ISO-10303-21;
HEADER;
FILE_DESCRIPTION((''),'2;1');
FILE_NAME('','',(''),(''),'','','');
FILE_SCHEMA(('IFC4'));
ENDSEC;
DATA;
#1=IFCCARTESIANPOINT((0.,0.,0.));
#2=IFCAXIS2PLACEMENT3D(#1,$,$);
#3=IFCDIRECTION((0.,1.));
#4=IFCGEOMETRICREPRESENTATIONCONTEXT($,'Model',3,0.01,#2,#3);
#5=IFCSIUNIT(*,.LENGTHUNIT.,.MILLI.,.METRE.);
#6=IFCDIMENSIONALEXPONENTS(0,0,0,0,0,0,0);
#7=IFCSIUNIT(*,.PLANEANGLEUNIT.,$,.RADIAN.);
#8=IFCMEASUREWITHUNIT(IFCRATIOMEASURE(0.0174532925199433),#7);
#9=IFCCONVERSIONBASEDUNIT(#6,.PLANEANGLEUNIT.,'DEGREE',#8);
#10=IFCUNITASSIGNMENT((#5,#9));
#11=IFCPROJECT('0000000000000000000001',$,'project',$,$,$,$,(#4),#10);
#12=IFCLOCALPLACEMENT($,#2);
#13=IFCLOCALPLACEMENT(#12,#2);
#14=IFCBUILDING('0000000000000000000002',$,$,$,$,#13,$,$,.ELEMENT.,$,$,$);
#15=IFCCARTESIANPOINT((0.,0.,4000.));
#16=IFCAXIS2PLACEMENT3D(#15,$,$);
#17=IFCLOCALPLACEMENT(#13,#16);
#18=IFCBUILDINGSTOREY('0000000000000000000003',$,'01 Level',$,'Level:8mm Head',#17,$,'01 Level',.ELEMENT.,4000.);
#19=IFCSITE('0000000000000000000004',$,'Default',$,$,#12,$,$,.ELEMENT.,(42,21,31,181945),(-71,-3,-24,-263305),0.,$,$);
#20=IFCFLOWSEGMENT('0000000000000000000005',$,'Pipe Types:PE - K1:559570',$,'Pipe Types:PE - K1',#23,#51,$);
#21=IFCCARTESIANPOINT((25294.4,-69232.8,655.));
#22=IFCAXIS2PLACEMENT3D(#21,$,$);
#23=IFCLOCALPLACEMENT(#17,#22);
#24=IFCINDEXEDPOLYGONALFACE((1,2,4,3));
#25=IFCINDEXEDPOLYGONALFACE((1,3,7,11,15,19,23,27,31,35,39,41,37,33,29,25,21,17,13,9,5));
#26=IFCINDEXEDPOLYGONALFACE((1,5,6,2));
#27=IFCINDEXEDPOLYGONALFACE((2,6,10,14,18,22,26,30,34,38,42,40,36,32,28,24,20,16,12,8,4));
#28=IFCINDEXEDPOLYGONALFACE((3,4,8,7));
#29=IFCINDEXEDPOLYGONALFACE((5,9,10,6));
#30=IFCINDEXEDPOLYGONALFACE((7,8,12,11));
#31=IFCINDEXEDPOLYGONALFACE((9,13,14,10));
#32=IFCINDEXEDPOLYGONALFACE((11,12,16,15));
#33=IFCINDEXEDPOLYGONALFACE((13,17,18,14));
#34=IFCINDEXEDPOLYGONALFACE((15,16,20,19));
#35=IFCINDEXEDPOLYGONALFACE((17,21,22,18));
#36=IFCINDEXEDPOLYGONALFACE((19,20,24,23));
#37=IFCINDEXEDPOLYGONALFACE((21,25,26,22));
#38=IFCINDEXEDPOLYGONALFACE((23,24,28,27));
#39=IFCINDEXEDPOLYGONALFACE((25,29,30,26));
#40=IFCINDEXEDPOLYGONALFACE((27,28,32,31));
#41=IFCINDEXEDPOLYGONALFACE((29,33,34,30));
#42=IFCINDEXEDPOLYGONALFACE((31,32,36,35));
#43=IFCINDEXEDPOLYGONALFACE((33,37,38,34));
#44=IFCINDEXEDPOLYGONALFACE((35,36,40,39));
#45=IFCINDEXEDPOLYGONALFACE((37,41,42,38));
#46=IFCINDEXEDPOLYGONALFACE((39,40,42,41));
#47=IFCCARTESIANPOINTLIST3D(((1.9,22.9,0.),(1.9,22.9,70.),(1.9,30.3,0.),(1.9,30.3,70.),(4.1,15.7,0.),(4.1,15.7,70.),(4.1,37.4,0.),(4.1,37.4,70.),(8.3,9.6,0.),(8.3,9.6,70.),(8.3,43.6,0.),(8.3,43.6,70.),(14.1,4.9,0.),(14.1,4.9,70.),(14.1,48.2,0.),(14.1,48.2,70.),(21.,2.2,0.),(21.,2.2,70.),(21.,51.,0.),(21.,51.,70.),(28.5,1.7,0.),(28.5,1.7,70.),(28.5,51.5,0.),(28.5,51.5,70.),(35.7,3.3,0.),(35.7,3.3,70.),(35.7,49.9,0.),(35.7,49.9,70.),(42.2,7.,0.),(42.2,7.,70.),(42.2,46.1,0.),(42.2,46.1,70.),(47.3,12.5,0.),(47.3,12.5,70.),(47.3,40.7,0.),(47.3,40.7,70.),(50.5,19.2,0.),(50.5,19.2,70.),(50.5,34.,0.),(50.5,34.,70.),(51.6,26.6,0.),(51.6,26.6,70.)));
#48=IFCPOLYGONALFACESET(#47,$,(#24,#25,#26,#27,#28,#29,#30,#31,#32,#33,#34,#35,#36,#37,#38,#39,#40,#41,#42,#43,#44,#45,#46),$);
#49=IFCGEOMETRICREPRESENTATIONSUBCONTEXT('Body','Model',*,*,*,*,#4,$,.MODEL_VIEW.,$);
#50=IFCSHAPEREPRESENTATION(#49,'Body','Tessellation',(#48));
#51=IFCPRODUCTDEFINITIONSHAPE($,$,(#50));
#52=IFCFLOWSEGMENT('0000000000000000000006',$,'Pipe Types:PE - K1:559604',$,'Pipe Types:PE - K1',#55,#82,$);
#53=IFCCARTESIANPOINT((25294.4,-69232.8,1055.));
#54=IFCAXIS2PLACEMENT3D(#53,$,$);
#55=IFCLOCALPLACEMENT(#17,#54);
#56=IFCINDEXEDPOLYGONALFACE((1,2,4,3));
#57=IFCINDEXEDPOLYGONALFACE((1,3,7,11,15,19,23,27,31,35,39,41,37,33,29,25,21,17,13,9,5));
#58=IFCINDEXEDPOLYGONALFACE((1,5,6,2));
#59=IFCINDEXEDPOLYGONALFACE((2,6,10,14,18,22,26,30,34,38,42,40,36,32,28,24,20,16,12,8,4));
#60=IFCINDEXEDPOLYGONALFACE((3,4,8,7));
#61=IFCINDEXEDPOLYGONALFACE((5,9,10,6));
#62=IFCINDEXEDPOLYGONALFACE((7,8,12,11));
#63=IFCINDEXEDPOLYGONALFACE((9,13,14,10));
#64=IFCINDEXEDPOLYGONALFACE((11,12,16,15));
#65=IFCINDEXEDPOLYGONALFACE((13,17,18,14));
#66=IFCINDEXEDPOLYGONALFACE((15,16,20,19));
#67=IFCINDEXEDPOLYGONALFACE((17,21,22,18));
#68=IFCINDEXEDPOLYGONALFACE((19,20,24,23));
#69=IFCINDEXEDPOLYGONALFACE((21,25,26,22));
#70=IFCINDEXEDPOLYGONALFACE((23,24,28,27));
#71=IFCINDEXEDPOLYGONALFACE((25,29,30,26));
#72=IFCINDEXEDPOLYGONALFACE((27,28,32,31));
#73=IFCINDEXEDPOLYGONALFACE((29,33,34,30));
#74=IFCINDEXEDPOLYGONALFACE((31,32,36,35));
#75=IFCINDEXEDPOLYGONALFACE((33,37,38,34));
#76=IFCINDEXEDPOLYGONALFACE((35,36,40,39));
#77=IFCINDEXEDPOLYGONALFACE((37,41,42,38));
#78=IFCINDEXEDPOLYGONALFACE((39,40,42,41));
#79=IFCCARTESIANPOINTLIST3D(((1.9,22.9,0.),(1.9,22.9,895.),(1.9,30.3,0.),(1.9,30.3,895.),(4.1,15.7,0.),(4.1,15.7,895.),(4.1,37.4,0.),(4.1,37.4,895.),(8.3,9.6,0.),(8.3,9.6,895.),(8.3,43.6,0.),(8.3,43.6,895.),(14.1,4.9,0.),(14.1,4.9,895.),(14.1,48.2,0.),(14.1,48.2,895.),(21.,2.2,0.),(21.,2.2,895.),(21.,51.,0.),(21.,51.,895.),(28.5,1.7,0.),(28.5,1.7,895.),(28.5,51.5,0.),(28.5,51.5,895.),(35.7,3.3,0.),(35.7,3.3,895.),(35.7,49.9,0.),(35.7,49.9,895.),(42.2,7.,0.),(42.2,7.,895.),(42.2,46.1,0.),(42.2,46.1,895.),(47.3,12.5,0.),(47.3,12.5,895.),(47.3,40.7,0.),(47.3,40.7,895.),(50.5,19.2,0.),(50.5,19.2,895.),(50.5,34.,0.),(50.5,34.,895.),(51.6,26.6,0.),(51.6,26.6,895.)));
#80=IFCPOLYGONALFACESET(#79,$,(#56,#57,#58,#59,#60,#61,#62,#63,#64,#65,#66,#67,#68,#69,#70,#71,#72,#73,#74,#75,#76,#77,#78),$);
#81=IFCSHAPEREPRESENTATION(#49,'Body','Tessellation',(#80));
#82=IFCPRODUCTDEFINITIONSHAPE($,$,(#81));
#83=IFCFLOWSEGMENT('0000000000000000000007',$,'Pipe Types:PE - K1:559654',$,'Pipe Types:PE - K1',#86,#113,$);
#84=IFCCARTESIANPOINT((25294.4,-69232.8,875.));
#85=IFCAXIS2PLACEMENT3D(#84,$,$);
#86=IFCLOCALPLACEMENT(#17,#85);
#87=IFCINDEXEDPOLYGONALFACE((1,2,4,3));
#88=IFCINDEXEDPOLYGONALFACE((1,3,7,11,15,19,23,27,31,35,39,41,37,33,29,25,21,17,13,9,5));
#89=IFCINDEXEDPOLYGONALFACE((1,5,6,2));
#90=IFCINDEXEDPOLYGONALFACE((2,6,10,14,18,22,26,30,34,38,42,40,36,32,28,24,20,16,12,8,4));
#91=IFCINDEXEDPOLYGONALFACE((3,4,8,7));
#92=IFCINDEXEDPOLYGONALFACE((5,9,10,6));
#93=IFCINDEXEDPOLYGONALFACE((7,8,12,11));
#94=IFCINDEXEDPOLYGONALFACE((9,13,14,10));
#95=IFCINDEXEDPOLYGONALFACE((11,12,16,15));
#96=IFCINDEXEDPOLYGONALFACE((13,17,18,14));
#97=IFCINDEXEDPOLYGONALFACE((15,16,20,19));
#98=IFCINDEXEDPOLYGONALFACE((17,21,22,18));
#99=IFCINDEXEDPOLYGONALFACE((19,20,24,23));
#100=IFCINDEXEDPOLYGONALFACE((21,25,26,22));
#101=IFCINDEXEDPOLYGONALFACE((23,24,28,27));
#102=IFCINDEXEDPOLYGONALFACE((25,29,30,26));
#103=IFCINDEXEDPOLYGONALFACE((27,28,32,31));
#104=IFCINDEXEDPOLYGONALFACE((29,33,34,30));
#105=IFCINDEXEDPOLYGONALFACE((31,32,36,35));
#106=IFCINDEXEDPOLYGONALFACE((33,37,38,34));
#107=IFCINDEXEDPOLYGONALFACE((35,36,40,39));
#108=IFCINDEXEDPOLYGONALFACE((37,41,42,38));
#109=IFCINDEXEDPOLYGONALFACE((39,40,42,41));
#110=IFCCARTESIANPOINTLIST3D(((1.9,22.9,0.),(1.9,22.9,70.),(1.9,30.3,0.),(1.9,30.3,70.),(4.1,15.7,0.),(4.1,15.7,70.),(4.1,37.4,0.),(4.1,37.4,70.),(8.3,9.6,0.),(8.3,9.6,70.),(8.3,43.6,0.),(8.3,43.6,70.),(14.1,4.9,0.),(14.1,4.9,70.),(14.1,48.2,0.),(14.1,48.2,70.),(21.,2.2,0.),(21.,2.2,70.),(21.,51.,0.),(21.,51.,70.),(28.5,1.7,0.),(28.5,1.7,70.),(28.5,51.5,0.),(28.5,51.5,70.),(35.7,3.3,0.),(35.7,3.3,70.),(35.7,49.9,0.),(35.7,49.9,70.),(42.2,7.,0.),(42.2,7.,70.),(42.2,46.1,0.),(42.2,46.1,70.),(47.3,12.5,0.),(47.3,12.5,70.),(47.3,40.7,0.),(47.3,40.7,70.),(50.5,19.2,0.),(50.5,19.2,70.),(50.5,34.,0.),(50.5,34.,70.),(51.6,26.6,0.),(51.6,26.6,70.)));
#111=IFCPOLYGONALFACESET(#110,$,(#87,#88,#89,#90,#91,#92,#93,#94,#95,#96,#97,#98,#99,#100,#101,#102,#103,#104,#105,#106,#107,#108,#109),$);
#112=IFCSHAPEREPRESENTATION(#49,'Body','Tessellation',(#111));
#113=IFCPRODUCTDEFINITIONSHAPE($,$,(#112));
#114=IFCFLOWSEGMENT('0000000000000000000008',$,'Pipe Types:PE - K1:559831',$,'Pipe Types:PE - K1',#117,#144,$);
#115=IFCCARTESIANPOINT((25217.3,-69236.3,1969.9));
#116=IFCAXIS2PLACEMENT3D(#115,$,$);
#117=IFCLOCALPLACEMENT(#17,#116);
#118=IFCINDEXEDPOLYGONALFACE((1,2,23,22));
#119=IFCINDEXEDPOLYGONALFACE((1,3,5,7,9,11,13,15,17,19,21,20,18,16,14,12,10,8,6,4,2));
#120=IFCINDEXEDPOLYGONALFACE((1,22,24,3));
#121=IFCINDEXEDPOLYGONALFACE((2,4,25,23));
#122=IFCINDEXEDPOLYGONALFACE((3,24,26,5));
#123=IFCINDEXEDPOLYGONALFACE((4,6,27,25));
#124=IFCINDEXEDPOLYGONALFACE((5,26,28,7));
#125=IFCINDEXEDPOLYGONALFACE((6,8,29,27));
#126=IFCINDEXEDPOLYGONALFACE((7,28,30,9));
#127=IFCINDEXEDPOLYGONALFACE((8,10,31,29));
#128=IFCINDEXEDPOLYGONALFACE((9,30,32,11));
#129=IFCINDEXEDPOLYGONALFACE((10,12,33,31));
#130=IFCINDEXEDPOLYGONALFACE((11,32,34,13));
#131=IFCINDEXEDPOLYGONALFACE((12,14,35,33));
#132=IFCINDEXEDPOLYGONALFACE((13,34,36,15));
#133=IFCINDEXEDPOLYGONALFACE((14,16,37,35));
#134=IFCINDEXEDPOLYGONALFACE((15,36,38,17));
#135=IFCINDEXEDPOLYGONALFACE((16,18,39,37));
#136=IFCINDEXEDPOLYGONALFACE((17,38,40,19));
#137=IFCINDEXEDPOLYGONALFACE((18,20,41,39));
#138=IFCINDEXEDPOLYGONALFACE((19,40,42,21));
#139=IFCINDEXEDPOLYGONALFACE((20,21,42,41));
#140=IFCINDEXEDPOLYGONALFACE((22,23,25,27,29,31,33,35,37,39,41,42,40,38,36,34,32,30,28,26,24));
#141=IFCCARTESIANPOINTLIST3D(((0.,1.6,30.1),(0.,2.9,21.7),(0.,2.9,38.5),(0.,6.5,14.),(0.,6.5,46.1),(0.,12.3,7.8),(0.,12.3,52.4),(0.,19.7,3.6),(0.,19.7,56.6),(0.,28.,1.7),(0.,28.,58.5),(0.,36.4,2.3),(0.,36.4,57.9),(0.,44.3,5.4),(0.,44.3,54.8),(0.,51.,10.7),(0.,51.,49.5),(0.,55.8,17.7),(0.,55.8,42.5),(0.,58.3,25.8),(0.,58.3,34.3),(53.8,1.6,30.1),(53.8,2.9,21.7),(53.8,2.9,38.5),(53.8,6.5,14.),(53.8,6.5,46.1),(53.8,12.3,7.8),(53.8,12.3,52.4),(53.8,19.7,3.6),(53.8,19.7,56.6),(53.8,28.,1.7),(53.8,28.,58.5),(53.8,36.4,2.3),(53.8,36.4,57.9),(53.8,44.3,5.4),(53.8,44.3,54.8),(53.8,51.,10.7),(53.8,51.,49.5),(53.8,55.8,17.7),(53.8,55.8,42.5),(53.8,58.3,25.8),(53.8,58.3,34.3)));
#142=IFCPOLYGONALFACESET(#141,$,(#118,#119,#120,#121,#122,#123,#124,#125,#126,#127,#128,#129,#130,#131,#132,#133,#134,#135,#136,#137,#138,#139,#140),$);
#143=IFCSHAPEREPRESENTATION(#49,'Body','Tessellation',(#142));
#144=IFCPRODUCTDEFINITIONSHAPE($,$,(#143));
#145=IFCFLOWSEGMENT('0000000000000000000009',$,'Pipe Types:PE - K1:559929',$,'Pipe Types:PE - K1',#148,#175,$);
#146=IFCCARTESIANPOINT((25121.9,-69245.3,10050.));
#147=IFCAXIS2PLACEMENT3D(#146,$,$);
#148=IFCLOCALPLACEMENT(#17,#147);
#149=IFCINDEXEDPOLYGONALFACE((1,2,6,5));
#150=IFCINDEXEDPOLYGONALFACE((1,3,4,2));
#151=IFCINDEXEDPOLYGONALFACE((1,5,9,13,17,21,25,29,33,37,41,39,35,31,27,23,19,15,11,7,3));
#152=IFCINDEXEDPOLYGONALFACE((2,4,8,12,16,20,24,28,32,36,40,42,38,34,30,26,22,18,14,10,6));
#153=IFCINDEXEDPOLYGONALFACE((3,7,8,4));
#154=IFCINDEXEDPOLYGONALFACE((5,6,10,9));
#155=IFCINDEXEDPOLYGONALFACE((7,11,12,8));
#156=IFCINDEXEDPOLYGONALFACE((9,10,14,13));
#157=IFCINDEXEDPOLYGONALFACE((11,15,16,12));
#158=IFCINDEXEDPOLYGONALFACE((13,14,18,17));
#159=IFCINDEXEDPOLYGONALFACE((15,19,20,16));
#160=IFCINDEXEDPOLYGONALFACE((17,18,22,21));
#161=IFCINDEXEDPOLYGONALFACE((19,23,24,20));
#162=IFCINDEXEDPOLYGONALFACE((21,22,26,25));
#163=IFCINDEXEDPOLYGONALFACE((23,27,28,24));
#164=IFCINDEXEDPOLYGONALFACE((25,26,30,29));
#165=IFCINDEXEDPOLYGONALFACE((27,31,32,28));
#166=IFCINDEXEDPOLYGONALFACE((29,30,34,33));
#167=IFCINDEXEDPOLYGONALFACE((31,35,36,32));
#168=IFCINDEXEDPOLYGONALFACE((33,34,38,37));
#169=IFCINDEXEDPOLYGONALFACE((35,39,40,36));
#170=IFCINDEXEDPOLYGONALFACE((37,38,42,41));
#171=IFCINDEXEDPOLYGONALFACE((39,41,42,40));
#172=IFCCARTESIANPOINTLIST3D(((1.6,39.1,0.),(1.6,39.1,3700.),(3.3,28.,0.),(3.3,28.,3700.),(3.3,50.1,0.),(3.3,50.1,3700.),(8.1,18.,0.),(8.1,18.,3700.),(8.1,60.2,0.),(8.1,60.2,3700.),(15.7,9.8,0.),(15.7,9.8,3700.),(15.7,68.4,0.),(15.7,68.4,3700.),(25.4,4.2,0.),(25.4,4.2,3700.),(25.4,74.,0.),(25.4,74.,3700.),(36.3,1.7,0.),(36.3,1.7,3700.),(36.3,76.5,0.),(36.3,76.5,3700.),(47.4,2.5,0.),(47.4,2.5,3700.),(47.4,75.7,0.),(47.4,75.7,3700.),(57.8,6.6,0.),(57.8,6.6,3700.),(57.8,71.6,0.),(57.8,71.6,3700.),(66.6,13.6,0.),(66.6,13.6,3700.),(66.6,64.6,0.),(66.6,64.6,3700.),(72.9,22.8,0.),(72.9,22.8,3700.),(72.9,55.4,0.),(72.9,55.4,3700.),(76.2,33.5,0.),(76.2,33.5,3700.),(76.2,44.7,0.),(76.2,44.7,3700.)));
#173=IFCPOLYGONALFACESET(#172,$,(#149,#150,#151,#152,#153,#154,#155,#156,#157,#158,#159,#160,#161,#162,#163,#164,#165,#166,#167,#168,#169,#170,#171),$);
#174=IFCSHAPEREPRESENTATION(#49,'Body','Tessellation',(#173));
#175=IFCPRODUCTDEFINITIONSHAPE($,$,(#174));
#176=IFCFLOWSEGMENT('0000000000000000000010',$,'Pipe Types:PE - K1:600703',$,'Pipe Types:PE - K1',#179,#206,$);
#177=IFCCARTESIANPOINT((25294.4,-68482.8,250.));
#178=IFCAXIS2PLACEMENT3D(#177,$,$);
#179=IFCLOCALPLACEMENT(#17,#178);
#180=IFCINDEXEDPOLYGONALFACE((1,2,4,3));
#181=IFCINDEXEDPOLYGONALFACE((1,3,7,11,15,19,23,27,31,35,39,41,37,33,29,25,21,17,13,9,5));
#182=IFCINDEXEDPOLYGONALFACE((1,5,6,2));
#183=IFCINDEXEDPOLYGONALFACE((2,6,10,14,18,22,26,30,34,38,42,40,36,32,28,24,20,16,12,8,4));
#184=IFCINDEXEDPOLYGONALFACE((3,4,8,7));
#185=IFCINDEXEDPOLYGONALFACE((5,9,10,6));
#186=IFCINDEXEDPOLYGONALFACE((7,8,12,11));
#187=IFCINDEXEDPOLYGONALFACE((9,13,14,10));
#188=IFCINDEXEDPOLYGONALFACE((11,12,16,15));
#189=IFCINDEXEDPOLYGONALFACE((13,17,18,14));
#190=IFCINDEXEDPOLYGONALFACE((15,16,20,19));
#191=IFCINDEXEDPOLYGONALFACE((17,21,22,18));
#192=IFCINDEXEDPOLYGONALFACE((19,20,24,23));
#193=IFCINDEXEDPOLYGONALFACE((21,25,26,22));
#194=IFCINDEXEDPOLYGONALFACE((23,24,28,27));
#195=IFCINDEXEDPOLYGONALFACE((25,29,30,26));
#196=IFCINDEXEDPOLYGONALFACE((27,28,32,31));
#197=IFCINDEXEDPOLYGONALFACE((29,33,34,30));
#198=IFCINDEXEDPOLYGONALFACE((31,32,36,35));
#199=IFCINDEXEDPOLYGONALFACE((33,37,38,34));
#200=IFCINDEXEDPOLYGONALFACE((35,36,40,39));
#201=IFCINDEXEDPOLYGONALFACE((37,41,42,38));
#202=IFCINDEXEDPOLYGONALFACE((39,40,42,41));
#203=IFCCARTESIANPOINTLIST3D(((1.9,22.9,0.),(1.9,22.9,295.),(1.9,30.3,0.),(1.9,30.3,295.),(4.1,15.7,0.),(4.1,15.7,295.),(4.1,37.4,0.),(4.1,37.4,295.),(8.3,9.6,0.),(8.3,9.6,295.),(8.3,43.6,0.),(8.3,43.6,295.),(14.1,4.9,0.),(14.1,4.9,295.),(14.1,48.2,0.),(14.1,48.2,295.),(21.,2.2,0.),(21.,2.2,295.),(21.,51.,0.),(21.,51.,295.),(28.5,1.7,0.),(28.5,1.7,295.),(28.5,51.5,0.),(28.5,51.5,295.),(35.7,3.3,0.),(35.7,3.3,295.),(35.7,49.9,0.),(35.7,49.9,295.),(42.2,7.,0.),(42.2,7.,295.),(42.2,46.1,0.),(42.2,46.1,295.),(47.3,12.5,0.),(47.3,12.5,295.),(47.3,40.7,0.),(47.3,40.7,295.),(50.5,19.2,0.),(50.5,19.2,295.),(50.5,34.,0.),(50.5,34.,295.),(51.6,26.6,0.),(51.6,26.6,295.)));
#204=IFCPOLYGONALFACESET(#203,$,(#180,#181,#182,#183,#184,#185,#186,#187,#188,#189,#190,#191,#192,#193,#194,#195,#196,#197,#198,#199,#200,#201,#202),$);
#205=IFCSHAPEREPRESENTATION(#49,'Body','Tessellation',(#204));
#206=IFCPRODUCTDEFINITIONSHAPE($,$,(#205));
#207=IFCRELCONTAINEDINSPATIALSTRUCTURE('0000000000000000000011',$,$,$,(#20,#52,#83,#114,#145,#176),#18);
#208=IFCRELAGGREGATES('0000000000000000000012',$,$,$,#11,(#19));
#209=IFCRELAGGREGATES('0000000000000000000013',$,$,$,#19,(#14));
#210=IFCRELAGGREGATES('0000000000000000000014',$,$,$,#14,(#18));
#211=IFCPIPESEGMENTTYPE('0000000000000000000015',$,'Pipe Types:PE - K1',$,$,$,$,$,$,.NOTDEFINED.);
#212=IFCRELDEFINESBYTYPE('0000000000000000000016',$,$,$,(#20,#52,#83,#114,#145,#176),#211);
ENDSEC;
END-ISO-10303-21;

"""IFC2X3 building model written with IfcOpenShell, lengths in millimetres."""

from ifc_helpers import new_model, entity, si_unit, converted_unit, direction, frame, origin, origin_2d_with_axis, place, context, subcontext, project, spatial, circle, extrude, type_object, element, save


model = new_model("IFC2X3")

# Units and contexts
model_context = context("Model", 3, precision=0.01, world=origin(), true_north=direction((0.0, 1.0)))
body_context = subcontext(model_context, "Body", "Model", "MODEL_VIEW")
ifc_project = project(units=[si_unit("LENGTHUNIT", "METRE", prefix="MILLI"), converted_unit("PLANEANGLEUNIT", "DEGREE", entity("IfcRatioMeasure", 0.0174532925199433), si_unit("PLANEANGLEUNIT", "RADIAN"), dimensions=[0, 0, 0, 0, 0, 0, 0])], contexts=[model_context])

# Site, building, storey
site_placement = place(None, origin())
site = spatial("IfcSite", under=ifc_project, at=site_placement, Name="Default", CompositionType="ELEMENT", RefLatitude=(42, 21, 31, 181945), RefLongitude=(-71, -3, -24, -263305), RefElevation=0.0)
building_placement = place(site_placement, origin())
building = spatial("IfcBuilding", under=site, at=building_placement, CompositionType="ELEMENT")
storey_placement = place(building_placement, frame((0.0, 0.0, 4000.0)))
storey = spatial("IfcBuildingStorey", under=building, at=storey_placement, Name="01 Level", ObjectType="Level:8mm Head", LongName="01 Level", CompositionType="ELEMENT", Elevation=4000.0)

# Flow segments
pipe_segment_type_1 = type_object("IfcPipeSegmentType", Name="Pipe Types:PE - K1", PredefinedType="NOTDEFINED")
flow_segment_1_placement = place(storey_placement, frame((25294.4, -69232.8, 655.0)))
element("IfcFlowSegment", 1, at=flow_segment_1_placement, inside=storey, type_object=pipe_segment_type_1, Name="Pipe Types:PE - K1:559570", ObjectType="Pipe Types:PE - K1", context=body_context, shape_type="SweptSolid", body=[
    extrude(circle(Radius=25.0, at=origin_2d_with_axis()), frame((26.6, 26.6, 0.0)), (0.0, 0.0, 1.0), 70.0),
])
flow_segment_2_placement = place(storey_placement, frame((25294.4, -69232.8, 1055.0)))
element("IfcFlowSegment", 2, at=flow_segment_2_placement, inside=storey, type_object=pipe_segment_type_1, Name="Pipe Types:PE - K1:559604", ObjectType="Pipe Types:PE - K1", context=body_context, shape_type="SweptSolid", body=[
    extrude(circle(Radius=25.0, at=origin_2d_with_axis()), frame((26.6, 26.6, 0.0)), (0.0, 0.0, 1.0), 895.0),
])
flow_segment_3_placement = place(storey_placement, frame((25294.4, -69232.8, 875.0)))
element("IfcFlowSegment", 3, at=flow_segment_3_placement, inside=storey, type_object=pipe_segment_type_1, Name="Pipe Types:PE - K1:559654", ObjectType="Pipe Types:PE - K1", context=body_context, shape_type="SweptSolid", body=[
    extrude(circle(Radius=25.0, at=origin_2d_with_axis()), frame((26.6, 26.6, 0.0)), (0.0, 0.0, 1.0), 70.0),
])
flow_segment_4_placement = place(storey_placement, frame((25217.3, -69236.3, 1969.9)))
element("IfcFlowSegment", 4, at=flow_segment_4_placement, inside=storey, type_object=pipe_segment_type_1, Name="Pipe Types:PE - K1:559831", ObjectType="Pipe Types:PE - K1", context=body_context, shape_type="SweptSolid", body=[
    extrude(circle(Radius=28.5, at=origin_2d_with_axis()), frame((0.0, 30.1, 30.1), z_axis=(1.0, 0.0, 0.0), x_axis=(0.0, -1.0, 0.0)), (0.0, 0.0, 1.0), 53.8),
])
flow_segment_5_placement = place(storey_placement, frame((25121.9, -69245.3, 10050.0)))
element("IfcFlowSegment", 5, at=flow_segment_5_placement, inside=storey, type_object=pipe_segment_type_1, Name="Pipe Types:PE - K1:559929", ObjectType="Pipe Types:PE - K1", context=body_context, shape_type="SweptSolid", body=[
    extrude(circle(Radius=37.5, at=origin_2d_with_axis()), frame((39.1, 39.1, 0.0), z_axis=(0.0, 0.0, 1.0), x_axis=(-1.0, 0.0, 0.0)), (0.0, 0.0, 1.0), 3700.0),
])
flow_segment_6_placement = place(storey_placement, frame((25294.4, -68482.8, 250.0)))
element("IfcFlowSegment", 6, at=flow_segment_6_placement, inside=storey, type_object=pipe_segment_type_1, Name="Pipe Types:PE - K1:600703", ObjectType="Pipe Types:PE - K1", context=body_context, shape_type="SweptSolid", body=[
    extrude(circle(Radius=25.0, at=origin_2d_with_axis()), frame((26.6, 26.6, 0.0)), (0.0, 0.0, 1.0), 295.0),
])

save(model, "model.ifc")
